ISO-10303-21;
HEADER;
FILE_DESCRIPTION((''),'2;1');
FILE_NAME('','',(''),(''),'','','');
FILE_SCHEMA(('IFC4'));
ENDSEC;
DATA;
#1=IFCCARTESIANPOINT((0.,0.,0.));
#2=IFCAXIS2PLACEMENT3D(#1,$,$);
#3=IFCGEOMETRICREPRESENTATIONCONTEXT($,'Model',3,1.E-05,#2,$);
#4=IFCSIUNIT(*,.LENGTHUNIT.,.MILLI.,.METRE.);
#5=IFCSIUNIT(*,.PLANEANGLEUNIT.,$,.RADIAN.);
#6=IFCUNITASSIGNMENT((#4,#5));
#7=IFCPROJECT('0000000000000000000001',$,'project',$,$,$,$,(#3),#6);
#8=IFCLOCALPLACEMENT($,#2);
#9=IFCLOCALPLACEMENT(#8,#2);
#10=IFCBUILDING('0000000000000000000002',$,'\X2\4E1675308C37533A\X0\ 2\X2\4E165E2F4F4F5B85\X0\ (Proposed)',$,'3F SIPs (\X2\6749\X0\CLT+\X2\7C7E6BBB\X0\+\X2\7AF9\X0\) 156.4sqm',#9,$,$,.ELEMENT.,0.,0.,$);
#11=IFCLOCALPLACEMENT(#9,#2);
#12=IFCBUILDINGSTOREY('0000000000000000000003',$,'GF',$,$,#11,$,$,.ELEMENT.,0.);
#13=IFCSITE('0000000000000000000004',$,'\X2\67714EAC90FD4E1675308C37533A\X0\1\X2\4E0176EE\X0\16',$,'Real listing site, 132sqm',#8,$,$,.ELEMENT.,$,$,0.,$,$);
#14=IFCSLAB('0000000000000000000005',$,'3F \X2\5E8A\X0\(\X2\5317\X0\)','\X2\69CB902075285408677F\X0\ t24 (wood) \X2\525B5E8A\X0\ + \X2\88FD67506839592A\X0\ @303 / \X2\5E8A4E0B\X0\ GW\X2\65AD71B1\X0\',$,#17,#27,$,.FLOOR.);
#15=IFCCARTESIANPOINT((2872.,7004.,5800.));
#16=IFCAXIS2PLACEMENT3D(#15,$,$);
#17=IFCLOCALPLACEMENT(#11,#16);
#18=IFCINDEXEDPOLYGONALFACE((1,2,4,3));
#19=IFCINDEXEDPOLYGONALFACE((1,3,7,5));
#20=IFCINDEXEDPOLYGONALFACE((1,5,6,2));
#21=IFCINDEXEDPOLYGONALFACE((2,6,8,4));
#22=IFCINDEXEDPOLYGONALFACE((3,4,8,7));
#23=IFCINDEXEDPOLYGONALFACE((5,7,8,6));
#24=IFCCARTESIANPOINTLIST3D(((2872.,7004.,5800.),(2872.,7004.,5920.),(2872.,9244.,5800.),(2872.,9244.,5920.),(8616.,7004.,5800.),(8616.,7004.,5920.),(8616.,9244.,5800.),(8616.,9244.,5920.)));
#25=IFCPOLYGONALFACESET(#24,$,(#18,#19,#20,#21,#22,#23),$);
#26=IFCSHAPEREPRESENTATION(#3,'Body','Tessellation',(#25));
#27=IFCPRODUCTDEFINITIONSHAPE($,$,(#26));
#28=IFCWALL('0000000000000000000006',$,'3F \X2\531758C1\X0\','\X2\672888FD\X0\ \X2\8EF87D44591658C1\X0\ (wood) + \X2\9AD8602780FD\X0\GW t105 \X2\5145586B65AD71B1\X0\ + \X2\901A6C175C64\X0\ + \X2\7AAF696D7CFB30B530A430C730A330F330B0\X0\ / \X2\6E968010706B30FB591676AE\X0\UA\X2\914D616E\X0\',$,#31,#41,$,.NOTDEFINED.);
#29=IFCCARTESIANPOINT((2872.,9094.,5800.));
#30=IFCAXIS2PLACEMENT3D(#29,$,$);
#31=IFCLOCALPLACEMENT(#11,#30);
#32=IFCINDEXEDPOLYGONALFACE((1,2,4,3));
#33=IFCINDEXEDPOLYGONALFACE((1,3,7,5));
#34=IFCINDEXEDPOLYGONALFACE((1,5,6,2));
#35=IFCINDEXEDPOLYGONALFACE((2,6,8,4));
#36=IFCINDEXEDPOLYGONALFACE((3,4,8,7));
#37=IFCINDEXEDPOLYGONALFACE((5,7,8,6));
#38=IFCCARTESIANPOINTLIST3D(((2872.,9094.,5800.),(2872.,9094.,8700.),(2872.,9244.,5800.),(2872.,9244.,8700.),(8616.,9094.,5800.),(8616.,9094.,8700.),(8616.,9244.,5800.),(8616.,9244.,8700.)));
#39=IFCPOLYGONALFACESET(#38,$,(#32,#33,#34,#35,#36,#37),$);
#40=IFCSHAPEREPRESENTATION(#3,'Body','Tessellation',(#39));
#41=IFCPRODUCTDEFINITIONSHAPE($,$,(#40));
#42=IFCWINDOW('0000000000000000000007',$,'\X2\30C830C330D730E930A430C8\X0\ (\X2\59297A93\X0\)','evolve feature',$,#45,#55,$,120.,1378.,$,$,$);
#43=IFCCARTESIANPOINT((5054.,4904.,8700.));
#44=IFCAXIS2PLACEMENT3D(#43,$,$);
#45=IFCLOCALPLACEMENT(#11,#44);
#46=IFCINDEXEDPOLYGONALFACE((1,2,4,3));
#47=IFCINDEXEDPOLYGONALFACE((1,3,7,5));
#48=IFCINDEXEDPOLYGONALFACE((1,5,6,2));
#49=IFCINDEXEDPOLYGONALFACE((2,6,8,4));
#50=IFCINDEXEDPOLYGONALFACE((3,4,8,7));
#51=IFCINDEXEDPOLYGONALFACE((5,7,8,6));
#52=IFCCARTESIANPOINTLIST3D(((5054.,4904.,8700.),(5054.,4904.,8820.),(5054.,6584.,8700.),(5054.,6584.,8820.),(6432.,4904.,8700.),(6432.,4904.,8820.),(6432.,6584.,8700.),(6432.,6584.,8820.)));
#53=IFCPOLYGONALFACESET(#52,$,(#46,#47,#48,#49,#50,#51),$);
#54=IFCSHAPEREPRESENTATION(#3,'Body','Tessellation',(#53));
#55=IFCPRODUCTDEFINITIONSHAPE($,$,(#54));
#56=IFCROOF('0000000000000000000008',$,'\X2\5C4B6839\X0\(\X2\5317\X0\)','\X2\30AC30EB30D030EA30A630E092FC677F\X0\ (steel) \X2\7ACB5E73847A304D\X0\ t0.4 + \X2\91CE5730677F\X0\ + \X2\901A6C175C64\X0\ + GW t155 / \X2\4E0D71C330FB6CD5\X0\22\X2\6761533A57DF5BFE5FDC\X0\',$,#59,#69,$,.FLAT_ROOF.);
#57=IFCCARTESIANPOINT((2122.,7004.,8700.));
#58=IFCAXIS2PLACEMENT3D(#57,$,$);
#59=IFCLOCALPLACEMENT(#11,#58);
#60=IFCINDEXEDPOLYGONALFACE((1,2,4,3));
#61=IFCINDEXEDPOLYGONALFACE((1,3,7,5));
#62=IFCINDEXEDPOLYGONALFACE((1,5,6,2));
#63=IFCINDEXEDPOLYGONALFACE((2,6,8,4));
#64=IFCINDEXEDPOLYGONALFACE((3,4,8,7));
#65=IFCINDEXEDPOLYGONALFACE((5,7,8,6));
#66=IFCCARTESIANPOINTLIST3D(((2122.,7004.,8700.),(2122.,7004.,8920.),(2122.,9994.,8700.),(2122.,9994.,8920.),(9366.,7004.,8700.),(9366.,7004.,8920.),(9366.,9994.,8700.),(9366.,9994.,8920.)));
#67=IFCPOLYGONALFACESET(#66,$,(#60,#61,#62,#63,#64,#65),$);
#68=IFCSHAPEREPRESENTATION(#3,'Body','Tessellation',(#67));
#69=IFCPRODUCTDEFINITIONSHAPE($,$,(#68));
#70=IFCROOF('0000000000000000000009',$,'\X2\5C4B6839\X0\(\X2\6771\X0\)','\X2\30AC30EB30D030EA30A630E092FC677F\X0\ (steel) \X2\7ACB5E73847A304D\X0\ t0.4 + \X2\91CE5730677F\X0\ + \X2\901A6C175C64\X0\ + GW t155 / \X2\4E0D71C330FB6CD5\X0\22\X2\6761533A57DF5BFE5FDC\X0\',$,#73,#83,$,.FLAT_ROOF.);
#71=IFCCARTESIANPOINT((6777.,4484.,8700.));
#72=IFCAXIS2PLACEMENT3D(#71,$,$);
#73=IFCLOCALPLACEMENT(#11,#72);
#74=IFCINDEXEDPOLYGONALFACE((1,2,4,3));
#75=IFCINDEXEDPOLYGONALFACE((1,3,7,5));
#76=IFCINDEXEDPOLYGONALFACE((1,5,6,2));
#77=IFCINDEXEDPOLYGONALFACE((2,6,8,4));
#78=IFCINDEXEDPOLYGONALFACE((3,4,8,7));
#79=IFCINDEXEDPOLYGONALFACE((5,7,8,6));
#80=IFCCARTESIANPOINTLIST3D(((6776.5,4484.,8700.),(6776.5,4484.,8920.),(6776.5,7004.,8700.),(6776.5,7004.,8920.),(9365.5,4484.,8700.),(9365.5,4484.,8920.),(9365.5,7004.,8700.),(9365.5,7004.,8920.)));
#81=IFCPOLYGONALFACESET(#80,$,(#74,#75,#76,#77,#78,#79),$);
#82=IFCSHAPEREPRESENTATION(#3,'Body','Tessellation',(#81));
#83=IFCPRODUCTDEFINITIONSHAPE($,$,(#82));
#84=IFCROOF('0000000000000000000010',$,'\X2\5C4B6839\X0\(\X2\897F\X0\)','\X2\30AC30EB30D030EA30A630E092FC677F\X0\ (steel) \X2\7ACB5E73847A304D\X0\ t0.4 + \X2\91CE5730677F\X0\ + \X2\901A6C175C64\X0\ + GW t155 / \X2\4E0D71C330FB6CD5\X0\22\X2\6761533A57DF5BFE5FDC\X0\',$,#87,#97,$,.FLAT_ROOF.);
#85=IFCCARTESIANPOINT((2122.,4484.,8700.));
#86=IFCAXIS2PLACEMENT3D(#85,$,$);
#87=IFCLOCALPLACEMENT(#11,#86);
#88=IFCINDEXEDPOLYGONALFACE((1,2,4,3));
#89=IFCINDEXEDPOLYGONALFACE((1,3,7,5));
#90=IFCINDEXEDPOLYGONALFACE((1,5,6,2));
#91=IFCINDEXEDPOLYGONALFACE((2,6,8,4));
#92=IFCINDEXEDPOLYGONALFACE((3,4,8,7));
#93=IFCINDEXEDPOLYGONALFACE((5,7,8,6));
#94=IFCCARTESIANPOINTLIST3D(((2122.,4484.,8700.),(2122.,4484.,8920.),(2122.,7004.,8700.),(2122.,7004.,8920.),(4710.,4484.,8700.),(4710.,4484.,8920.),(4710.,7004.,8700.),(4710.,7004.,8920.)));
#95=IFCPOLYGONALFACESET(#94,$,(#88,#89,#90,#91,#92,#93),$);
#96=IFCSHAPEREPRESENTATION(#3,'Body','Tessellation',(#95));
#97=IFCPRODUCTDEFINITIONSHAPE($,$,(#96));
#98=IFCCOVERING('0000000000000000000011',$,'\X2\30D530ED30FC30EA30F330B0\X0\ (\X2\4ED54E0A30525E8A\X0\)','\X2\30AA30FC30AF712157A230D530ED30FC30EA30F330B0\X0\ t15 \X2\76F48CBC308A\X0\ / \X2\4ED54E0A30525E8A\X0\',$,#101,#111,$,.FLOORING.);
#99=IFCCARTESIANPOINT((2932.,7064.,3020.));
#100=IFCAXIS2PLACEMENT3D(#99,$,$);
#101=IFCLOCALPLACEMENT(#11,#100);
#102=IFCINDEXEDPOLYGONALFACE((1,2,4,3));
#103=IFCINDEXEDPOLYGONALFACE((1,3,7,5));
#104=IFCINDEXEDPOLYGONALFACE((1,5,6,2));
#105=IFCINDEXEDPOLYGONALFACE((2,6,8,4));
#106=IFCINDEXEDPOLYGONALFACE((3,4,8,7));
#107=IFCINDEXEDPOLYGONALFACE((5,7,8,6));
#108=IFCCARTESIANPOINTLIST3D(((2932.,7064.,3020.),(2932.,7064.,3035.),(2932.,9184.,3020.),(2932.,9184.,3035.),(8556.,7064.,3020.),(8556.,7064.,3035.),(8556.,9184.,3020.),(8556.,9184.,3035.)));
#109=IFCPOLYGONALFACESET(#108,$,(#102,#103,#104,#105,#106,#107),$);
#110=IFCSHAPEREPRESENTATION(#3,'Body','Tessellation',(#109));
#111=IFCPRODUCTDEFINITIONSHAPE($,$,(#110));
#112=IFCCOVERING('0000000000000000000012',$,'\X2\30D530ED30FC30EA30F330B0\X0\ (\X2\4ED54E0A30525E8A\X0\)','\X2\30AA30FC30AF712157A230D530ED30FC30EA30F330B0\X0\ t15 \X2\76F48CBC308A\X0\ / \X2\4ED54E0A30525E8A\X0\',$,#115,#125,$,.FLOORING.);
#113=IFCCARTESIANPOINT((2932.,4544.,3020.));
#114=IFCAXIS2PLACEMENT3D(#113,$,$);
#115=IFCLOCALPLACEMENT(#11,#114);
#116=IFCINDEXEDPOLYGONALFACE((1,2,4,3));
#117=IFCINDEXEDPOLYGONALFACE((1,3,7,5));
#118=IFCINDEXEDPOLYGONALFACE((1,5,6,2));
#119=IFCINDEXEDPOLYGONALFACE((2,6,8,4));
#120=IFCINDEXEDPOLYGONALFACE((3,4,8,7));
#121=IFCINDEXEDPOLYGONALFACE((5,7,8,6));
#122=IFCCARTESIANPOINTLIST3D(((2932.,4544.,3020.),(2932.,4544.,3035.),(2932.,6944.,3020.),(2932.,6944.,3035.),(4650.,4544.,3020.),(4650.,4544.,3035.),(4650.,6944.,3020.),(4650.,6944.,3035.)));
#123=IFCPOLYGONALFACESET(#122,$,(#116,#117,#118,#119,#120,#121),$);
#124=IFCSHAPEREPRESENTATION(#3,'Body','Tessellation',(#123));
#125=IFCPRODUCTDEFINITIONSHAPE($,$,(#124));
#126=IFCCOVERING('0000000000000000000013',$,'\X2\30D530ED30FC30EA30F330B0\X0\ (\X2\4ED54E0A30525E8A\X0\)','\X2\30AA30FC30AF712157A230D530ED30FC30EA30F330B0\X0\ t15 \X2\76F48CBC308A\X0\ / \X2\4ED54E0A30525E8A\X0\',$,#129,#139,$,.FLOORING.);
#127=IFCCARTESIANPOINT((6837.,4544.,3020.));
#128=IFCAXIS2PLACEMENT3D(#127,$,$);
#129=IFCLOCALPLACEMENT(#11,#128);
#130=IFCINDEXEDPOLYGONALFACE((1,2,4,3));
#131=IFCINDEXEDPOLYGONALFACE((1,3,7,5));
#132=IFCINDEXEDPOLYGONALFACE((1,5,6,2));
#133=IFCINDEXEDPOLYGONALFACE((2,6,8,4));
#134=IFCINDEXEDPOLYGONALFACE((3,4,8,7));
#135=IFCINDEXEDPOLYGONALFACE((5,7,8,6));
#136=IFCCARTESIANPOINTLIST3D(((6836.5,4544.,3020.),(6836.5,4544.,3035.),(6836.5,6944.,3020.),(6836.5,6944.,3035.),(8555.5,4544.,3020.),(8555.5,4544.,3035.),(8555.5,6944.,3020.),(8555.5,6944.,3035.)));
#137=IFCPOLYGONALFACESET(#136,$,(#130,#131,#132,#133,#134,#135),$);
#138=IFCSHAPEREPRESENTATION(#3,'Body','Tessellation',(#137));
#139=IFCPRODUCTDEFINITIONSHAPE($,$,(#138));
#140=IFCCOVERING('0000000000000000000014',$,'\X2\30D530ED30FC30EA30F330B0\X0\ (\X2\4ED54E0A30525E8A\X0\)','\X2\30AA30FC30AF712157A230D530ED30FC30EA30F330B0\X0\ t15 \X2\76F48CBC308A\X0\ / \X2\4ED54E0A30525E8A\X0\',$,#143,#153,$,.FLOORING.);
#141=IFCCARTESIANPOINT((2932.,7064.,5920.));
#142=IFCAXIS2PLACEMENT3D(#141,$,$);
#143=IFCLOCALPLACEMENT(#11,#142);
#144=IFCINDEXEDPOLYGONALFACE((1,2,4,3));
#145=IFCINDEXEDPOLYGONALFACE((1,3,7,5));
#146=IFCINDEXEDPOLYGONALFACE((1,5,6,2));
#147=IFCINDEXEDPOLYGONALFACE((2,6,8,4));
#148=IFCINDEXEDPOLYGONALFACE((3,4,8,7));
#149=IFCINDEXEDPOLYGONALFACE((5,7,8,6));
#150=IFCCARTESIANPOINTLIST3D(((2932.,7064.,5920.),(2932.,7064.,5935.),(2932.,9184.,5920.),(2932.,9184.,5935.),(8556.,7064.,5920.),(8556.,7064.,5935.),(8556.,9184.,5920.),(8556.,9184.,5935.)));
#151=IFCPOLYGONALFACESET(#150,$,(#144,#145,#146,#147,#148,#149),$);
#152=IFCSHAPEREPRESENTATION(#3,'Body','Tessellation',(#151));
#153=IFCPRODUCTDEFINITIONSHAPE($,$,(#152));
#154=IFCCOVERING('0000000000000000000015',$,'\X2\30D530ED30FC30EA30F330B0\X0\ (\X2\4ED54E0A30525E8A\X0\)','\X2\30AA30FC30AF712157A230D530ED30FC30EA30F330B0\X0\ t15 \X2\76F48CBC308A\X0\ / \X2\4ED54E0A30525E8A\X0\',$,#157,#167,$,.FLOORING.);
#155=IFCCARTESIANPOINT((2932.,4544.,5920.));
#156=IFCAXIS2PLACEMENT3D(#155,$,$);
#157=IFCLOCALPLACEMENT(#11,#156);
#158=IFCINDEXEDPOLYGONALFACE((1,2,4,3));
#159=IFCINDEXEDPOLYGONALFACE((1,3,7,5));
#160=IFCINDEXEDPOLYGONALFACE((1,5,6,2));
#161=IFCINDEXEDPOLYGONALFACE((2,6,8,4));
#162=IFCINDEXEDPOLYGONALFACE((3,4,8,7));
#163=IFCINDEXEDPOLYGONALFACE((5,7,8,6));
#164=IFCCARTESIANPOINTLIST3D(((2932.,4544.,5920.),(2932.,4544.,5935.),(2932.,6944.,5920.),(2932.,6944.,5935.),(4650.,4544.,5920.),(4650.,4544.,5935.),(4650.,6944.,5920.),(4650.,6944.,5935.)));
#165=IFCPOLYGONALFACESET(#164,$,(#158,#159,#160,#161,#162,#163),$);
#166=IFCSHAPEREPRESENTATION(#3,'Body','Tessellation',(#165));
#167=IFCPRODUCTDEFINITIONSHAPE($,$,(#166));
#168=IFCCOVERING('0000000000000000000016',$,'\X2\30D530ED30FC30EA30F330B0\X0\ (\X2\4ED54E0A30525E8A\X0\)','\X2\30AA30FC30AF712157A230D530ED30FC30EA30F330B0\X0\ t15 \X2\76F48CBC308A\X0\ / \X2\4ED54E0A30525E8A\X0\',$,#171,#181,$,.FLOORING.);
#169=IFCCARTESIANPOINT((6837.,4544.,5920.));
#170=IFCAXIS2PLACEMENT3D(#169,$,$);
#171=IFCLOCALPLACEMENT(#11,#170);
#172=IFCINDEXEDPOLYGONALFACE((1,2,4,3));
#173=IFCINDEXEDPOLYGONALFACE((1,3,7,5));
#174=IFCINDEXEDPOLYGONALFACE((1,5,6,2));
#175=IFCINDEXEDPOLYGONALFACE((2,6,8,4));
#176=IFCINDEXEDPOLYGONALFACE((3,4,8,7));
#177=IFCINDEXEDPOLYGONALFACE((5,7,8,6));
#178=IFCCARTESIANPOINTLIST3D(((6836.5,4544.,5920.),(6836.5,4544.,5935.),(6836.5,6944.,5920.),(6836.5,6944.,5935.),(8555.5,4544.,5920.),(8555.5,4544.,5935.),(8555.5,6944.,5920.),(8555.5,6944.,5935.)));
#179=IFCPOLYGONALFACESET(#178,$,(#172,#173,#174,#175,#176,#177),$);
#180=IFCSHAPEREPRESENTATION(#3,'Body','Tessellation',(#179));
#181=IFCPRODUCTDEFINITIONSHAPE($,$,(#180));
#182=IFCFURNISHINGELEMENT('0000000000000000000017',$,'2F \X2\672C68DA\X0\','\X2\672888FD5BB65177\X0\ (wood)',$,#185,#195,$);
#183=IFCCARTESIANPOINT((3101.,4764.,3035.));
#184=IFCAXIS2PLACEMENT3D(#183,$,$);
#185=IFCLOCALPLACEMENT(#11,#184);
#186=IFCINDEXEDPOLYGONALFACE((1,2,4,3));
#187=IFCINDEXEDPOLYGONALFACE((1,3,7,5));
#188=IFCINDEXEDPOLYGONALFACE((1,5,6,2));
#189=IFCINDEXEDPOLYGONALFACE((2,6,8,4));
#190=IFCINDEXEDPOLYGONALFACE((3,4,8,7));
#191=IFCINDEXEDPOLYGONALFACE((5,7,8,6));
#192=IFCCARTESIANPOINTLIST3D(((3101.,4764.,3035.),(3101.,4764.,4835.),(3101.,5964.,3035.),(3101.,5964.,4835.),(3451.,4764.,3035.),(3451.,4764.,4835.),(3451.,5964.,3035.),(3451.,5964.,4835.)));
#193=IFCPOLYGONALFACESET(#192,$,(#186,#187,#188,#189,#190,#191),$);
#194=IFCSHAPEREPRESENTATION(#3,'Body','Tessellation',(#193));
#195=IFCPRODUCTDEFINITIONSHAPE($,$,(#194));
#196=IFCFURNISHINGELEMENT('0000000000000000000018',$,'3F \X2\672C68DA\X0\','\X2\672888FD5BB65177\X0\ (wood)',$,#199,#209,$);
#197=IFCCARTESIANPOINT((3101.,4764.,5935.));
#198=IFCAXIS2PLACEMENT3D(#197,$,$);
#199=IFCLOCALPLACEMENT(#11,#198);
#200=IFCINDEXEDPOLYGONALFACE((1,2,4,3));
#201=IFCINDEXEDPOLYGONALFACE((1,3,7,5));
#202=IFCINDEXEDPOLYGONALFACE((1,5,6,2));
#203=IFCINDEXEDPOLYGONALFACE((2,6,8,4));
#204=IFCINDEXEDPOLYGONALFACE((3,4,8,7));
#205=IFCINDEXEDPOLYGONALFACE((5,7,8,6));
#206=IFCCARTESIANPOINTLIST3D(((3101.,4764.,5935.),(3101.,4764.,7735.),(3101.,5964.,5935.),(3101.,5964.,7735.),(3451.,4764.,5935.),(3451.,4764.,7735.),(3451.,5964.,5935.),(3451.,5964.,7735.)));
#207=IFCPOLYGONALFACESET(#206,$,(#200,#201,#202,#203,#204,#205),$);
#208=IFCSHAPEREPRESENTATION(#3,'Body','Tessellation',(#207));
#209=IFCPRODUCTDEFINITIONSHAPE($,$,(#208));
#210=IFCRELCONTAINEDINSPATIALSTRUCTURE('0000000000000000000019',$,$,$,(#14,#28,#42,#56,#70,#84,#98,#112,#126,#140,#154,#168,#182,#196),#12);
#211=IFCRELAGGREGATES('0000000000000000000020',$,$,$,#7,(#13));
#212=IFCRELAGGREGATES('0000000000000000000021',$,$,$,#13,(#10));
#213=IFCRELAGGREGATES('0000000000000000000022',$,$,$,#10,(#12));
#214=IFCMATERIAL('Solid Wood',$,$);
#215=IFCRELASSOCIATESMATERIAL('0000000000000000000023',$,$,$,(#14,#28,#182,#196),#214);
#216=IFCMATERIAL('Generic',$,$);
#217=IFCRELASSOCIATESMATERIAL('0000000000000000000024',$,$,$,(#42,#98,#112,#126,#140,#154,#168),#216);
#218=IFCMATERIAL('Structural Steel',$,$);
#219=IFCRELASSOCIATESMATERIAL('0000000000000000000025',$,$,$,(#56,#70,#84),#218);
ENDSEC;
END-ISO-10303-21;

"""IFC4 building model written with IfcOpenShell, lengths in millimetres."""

from ifc_helpers import new_model, si_unit, frame, frame_2d, origin, place, context, project, spatial, rectangle, extrude, material, element, save


model = new_model("IFC4")

# Units and contexts
model_context = context("Model", 3, precision=1e-05, world=origin())
ifc_project = project(units=[si_unit("LENGTHUNIT", "METRE", prefix="MILLI"), si_unit("PLANEANGLEUNIT", "RADIAN")], contexts=[model_context])

# Site, building, storey
site_placement = place(None, origin())
site = spatial("IfcSite", under=ifc_project, at=site_placement, Name="東京都世田谷区1丁目16", ObjectType="Real listing site, 132sqm", CompositionType="ELEMENT", RefElevation=0.0)
building_placement = place(site_placement, origin())
building = spatial("IfcBuilding", under=site, at=building_placement, Name="世田谷区 2世帯住宅 (Proposed)", ObjectType="3F SIPs (杉CLT+籾殻+竹) 156.4sqm", CompositionType="ELEMENT", ElevationOfRefHeight=0.0, ElevationOfTerrain=0.0)
storey_placement = place(building_placement, origin())
storey = spatial("IfcBuildingStorey", under=building, at=storey_placement, Name="GF", CompositionType="ELEMENT", Elevation=0.0)

# Slab
ifc_material_1 = material(Name="Solid Wood")
slab_placement = place(storey_placement, frame((2872.0, 7004.0, 5800.0)))
element("IfcSlab", 1, at=slab_placement, inside=storey, material=ifc_material_1, Name="3F 床(北)", Description="構造用合板 t24 (wood) 剛床 + 製材根太 @303 / 床下 GW断熱", PredefinedType="FLOOR", context=model_context, shape_type="SweptSolid", body=[
    extrude(rectangle(XDim=5744.0, YDim=2240.0, at=frame_2d((2872.0, 1120.0))), frame((2872.0, 7004.0, 5800.0)), (0.0, 0.0, 1.0), 120.0),
])

# Wall
wall_1_placement = place(storey_placement, frame((2872.0, 9094.0, 5800.0)))
element("IfcWall", 2, at=wall_1_placement, inside=storey, material=ifc_material_1, Name="3F 北壁", Description="木製 軸組外壁 (wood) + 高性能GW t105 充填断熱 + 通気層 + 窯業系サイディング / 準耐火・外皮UA配慮", PredefinedType="NOTDEFINED", context=model_context, shape_type="SweptSolid", body=[
    extrude(rectangle(XDim=5744.0, YDim=150.0, at=frame_2d((2872.0, 75.0))), frame((2872.0, 9094.0, 5800.0)), (0.0, 0.0, 1.0), 2900.0),
])

# Window
ifc_material_2 = material(Name="Generic")
window_1_placement = place(storey_placement, frame((5054.0, 4904.0, 8700.0)))
element("IfcWindow", 3, at=window_1_placement, inside=storey, material=ifc_material_2, Name="トップライト (天窓)", Description="evolve feature", OverallHeight=120.0, OverallWidth=1378.0, context=model_context, shape_type="SweptSolid", body=[
    extrude(rectangle(XDim=1378.0, YDim=1680.0, at=frame_2d((689.0, 840.0))), frame((5054.0, 4904.0, 8700.0)), (0.0, 0.0, 1.0), 120.0),
])

# Roofs
ifc_material_3 = material(Name="Structural Steel")
roof_1_placement = place(storey_placement, frame((2122.0, 7004.0, 8700.0)))
element("IfcRoof", 4, at=roof_1_placement, inside=storey, material=ifc_material_3, Name="屋根(北)", Description="ガルバリウム鋼板 (steel) 立平葺き t0.4 + 野地板 + 通気層 + GW t155 / 不燃・法22条区域対応", PredefinedType="FLAT_ROOF", context=model_context, shape_type="SweptSolid", body=[
    extrude(rectangle(XDim=7244.0, YDim=2990.0, at=frame_2d((3622.0, 1495.0))), frame((2122.0, 7004.0, 8700.0)), (0.0, 0.0, 1.0), 220.0),
])
roof_2_placement = place(storey_placement, frame((6777.0, 4484.0, 8700.0)))
element("IfcRoof", 5, at=roof_2_placement, inside=storey, material=ifc_material_3, Name="屋根(東)", Description="ガルバリウム鋼板 (steel) 立平葺き t0.4 + 野地板 + 通気層 + GW t155 / 不燃・法22条区域対応", PredefinedType="FLAT_ROOF", context=model_context, shape_type="SweptSolid", body=[
    extrude(rectangle(XDim=2589.0, YDim=2520.0, at=frame_2d((1294.0, 1260.0))), frame((6777.0, 4484.0, 8700.0)), (0.0, 0.0, 1.0), 220.0),
])
roof_3_placement = place(storey_placement, frame((2122.0, 4484.0, 8700.0)))
element("IfcRoof", 6, at=roof_3_placement, inside=storey, material=ifc_material_3, Name="屋根(西)", Description="ガルバリウム鋼板 (steel) 立平葺き t0.4 + 野地板 + 通気層 + GW t155 / 不燃・法22条区域対応", PredefinedType="FLAT_ROOF", context=model_context, shape_type="SweptSolid", body=[
    extrude(rectangle(XDim=2588.0, YDim=2520.0, at=frame_2d((1294.0, 1260.0))), frame((2122.0, 4484.0, 8700.0)), (0.0, 0.0, 1.0), 220.0),
])

# Coverings
covering_1_placement = place(storey_placement, frame((2932.0, 7064.0, 3020.0)))
element("IfcCovering", 7, at=covering_1_placement, inside=storey, material=ifc_material_2, Name="フローリング (仕上げ床)", Description="オーク無垢フローリング t15 直貼り / 仕上げ床", PredefinedType="FLOORING", context=model_context, shape_type="SweptSolid", body=[
    extrude(rectangle(XDim=5624.0, YDim=2120.0, at=frame_2d((2812.0, 1060.0))), frame((2932.0, 7064.0, 3020.0)), (0.0, 0.0, 1.0), 15.0),
])
covering_2_placement = place(storey_placement, frame((2932.0, 4544.0, 3020.0)))
element("IfcCovering", 8, at=covering_2_placement, inside=storey, material=ifc_material_2, Name="フローリング (仕上げ床)", Description="オーク無垢フローリング t15 直貼り / 仕上げ床", PredefinedType="FLOORING", context=model_context, shape_type="SweptSolid", body=[
    extrude(rectangle(XDim=1718.0, YDim=2400.0, at=frame_2d((859.0, 1200.0))), frame((2932.0, 4544.0, 3020.0)), (0.0, 0.0, 1.0), 15.0),
])
covering_3_placement = place(storey_placement, frame((6837.0, 4544.0, 3020.0)))
element("IfcCovering", 9, at=covering_3_placement, inside=storey, material=ifc_material_2, Name="フローリング (仕上げ床)", Description="オーク無垢フローリング t15 直貼り / 仕上げ床", PredefinedType="FLOORING", context=model_context, shape_type="SweptSolid", body=[
    extrude(rectangle(XDim=1719.0, YDim=2400.0, at=frame_2d((859.0, 1200.0))), frame((6837.0, 4544.0, 3020.0)), (0.0, 0.0, 1.0), 15.0),
])
covering_4_placement = place(storey_placement, frame((2932.0, 7064.0, 5920.0)))
element("IfcCovering", 10, at=covering_4_placement, inside=storey, material=ifc_material_2, Name="フローリング (仕上げ床)", Description="オーク無垢フローリング t15 直貼り / 仕上げ床", PredefinedType="FLOORING", context=model_context, shape_type="SweptSolid", body=[
    extrude(rectangle(XDim=5624.0, YDim=2120.0, at=frame_2d((2812.0, 1060.0))), frame((2932.0, 7064.0, 5920.0)), (0.0, 0.0, 1.0), 15.0),
])
covering_5_placement = place(storey_placement, frame((2932.0, 4544.0, 5920.0)))
element("IfcCovering", 11, at=covering_5_placement, inside=storey, material=ifc_material_2, Name="フローリング (仕上げ床)", Description="オーク無垢フローリング t15 直貼り / 仕上げ床", PredefinedType="FLOORING", context=model_context, shape_type="SweptSolid", body=[
    extrude(rectangle(XDim=1718.0, YDim=2400.0, at=frame_2d((859.0, 1200.0))), frame((2932.0, 4544.0, 5920.0)), (0.0, 0.0, 1.0), 15.0),
])
covering_6_placement = place(storey_placement, frame((6837.0, 4544.0, 5920.0)))
element("IfcCovering", 12, at=covering_6_placement, inside=storey, material=ifc_material_2, Name="フローリング (仕上げ床)", Description="オーク無垢フローリング t15 直貼り / 仕上げ床", PredefinedType="FLOORING", context=model_context, shape_type="SweptSolid", body=[
    extrude(rectangle(XDim=1719.0, YDim=2400.0, at=frame_2d((859.0, 1200.0))), frame((6837.0, 4544.0, 5920.0)), (0.0, 0.0, 1.0), 15.0),
])

# Furnishing elements
furnishing_1_placement = place(storey_placement, frame((3101.0, 4764.0, 3035.0)))
element("IfcFurnishingElement", 13, at=furnishing_1_placement, inside=storey, material=ifc_material_1, Name="2F 本棚", Description="木製家具 (wood)", context=model_context, shape_type="SweptSolid", body=[
    extrude(rectangle(XDim=350.0, YDim=1200.0, at=frame_2d((175.0, 600.0))), frame((3101.0, 4764.0, 3035.0)), (0.0, 0.0, 1.0), 1800.0),
])
furnishing_2_placement = place(storey_placement, frame((3101.0, 4764.0, 5935.0)))
element("IfcFurnishingElement", 14, at=furnishing_2_placement, inside=storey, material=ifc_material_1, Name="3F 本棚", Description="木製家具 (wood)", context=model_context, shape_type="SweptSolid", body=[
    extrude(rectangle(XDim=350.0, YDim=1200.0, at=frame_2d((175.0, 600.0))), frame((3101.0, 4764.0, 5935.0)), (0.0, 0.0, 1.0), 1800.0),
])

save(model, "model.ifc")
